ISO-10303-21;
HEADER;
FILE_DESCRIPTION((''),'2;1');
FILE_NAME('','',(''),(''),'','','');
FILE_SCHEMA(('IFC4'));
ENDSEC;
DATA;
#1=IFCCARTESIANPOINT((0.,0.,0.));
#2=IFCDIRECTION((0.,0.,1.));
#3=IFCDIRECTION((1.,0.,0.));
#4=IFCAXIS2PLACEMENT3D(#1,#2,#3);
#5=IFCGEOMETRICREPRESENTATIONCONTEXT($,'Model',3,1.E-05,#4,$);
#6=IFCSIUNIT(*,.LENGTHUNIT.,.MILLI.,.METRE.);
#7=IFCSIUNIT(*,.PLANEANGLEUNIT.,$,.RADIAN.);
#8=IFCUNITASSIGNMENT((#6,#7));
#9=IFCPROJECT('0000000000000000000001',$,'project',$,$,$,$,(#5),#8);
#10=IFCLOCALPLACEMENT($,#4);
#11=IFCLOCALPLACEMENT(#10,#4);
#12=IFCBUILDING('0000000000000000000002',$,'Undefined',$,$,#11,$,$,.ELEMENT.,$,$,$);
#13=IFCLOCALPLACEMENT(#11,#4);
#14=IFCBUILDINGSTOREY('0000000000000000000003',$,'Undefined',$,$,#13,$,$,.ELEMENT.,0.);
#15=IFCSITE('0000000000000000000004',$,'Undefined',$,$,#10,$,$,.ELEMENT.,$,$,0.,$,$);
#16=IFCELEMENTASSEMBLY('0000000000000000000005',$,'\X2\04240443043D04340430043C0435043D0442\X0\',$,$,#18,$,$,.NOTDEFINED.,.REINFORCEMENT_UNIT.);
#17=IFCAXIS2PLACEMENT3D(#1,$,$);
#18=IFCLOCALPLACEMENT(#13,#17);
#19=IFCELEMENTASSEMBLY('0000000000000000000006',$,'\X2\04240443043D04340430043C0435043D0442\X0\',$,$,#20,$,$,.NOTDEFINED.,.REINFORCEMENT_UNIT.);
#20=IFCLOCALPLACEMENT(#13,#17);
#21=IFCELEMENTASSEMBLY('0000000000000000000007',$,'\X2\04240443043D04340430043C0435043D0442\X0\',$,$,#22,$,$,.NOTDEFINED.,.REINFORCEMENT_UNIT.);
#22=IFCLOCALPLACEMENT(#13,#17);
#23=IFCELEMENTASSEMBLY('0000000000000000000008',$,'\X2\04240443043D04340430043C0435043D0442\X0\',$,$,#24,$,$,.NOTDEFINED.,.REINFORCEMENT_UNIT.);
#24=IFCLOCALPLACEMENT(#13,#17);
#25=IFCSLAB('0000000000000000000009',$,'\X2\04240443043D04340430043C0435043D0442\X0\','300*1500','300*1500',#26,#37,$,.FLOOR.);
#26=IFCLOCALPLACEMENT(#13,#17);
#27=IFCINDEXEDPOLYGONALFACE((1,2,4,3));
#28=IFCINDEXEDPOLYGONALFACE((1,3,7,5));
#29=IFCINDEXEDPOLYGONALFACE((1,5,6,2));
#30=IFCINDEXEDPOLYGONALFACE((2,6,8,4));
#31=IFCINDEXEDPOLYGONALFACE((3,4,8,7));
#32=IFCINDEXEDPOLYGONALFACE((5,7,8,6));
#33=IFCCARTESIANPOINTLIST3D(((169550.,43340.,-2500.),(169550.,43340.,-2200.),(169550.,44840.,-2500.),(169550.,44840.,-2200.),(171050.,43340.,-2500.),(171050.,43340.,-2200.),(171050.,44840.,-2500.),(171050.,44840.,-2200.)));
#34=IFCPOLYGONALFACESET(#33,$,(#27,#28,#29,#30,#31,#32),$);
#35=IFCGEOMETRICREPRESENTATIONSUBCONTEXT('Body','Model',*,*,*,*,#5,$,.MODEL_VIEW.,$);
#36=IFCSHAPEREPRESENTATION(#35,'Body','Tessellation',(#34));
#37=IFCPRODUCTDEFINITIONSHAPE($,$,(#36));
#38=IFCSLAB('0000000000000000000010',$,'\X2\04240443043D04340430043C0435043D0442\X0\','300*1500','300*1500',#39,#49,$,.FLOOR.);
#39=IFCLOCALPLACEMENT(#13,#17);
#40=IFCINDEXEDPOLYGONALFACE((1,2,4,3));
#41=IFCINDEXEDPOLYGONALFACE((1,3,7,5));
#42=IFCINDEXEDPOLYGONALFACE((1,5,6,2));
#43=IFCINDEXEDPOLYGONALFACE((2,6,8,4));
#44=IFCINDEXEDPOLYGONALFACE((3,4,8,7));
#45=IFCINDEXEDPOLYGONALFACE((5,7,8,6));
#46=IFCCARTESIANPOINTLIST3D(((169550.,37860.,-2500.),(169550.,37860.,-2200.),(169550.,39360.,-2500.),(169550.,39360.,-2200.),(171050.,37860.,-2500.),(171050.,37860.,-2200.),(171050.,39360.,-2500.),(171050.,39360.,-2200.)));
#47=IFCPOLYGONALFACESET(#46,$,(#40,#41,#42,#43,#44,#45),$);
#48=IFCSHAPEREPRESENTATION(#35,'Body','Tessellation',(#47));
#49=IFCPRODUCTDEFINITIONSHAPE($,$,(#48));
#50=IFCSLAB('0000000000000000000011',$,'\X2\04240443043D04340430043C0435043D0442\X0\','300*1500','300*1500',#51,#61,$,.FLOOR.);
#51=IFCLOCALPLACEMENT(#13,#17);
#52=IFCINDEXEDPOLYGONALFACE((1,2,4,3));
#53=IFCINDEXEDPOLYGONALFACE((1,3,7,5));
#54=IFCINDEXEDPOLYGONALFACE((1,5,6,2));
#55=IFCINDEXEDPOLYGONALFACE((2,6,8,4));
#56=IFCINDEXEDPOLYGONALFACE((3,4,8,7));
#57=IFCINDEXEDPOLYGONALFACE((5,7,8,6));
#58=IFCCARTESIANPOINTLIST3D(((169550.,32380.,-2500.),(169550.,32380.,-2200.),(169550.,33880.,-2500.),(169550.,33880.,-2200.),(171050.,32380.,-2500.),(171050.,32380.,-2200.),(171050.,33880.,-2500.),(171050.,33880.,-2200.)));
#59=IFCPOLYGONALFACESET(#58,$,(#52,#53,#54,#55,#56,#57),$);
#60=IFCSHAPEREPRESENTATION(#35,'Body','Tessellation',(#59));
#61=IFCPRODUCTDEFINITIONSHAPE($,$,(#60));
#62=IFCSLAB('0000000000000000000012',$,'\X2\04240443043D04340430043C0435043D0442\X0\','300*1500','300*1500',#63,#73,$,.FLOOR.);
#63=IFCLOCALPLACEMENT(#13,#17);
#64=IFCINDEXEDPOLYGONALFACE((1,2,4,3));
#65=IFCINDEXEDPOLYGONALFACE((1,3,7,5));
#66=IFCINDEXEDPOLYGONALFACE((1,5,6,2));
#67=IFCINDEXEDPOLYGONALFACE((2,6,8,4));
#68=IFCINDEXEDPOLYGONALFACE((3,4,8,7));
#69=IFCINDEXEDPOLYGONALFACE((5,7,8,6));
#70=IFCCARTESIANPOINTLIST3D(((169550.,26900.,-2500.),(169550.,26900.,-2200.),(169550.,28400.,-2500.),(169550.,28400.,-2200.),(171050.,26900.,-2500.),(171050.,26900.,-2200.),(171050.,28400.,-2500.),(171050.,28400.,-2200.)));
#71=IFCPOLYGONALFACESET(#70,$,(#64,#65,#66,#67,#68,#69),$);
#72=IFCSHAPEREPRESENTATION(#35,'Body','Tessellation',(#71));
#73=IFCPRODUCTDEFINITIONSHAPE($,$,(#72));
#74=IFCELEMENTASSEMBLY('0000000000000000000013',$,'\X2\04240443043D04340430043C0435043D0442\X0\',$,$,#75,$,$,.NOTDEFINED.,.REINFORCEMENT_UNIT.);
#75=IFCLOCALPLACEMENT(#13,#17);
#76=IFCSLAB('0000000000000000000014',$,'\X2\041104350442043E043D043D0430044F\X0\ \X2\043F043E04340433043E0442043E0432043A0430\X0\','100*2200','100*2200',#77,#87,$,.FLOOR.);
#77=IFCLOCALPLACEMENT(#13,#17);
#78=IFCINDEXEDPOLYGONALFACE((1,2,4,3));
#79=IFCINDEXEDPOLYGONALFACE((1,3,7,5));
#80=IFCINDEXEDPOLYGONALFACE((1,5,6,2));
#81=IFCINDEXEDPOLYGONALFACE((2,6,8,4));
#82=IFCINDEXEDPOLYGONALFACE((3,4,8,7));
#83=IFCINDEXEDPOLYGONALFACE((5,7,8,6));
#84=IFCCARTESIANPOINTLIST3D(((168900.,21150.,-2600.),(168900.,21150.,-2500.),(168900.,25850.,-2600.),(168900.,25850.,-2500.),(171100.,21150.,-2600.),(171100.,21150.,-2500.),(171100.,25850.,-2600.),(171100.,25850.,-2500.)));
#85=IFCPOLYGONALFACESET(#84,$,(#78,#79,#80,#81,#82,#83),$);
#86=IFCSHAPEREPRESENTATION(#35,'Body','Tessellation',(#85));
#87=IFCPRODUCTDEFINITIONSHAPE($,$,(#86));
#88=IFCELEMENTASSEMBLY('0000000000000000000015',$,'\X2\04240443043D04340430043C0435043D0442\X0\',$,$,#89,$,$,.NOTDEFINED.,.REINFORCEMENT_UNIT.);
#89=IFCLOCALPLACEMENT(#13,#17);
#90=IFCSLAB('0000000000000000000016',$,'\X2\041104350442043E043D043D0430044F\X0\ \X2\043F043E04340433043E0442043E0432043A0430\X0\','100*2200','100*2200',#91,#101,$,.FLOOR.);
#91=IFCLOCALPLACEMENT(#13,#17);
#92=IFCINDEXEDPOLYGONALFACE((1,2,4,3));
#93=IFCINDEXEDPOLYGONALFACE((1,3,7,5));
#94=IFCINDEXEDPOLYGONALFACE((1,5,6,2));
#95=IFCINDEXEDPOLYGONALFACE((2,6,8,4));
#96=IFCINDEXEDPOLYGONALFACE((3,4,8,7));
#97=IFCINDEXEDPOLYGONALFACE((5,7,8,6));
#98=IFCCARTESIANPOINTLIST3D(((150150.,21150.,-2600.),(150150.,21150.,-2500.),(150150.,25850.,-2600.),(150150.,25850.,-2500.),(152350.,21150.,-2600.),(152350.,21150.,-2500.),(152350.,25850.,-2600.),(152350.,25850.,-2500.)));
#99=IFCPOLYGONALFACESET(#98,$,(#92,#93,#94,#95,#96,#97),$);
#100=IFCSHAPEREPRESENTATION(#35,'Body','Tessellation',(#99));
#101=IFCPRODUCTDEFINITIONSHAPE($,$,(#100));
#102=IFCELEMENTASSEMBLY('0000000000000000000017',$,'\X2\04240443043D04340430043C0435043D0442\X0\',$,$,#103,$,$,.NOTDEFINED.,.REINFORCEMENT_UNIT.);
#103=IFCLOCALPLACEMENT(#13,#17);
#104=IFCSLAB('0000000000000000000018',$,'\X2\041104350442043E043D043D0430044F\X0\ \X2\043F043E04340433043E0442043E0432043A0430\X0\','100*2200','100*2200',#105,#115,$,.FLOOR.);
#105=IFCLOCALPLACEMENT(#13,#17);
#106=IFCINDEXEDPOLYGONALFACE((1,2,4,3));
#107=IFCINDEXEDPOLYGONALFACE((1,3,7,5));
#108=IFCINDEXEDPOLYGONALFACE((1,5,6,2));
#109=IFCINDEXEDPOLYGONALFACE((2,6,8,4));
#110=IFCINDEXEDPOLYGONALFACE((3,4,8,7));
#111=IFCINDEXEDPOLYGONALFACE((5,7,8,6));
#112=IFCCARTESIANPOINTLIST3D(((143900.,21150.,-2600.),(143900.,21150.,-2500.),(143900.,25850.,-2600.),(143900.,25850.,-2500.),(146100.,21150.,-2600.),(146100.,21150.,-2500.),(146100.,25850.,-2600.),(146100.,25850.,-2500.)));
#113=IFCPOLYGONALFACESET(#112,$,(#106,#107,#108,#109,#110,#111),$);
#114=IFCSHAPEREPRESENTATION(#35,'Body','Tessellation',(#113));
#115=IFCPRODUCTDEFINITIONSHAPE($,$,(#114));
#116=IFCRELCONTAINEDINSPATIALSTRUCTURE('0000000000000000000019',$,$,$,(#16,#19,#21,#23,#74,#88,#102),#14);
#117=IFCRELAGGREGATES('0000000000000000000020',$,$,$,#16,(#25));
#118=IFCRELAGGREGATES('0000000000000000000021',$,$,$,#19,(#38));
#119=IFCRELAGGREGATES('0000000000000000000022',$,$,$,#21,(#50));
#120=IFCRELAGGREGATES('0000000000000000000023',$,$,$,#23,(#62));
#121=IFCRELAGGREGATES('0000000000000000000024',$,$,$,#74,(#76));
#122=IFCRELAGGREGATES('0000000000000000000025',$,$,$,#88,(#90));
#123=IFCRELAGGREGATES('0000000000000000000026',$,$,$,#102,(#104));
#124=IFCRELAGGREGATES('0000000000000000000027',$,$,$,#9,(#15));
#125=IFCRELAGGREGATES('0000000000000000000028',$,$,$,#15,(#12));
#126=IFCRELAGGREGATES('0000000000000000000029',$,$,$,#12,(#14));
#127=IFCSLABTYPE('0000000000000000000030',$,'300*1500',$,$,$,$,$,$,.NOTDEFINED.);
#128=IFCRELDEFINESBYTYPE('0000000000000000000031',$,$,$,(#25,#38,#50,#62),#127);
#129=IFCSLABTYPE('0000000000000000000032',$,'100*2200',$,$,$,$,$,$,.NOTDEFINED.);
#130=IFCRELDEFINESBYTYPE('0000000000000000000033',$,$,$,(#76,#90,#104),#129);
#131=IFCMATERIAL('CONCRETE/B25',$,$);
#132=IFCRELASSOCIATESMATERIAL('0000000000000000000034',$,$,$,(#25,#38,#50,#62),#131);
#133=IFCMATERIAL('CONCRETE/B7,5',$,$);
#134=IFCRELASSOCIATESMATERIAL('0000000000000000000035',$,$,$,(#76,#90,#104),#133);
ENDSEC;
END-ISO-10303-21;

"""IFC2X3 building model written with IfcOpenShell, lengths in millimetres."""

from ifc_helpers import new_model, si_unit, frame, origin_with_axes, place, context, subcontext, project, spatial, polyline, outline, extrude, material, type_object, element, aggregate, save


model = new_model("IFC2X3")

# Units and contexts
model_context = context("Model", 3, precision=1e-05, world=origin_with_axes())
body_context = subcontext(model_context, "Body", "Model", "MODEL_VIEW")
ifc_project = project(units=[si_unit("LENGTHUNIT", "METRE", prefix="MILLI"), si_unit("PLANEANGLEUNIT", "RADIAN")], contexts=[model_context])

# Site, building, storey
site_placement = place(None, origin_with_axes())
site = spatial("IfcSite", under=ifc_project, at=site_placement, Name="Undefined", CompositionType="ELEMENT", RefElevation=0.0)
building_placement = place(site_placement, origin_with_axes())
building = spatial("IfcBuilding", under=site, at=building_placement, Name="Undefined", CompositionType="ELEMENT")
storey_placement = place(building_placement, origin_with_axes())
storey = spatial("IfcBuildingStorey", under=building, at=storey_placement, Name="Undefined", CompositionType="ELEMENT", Elevation=0.0)

# Element assemblies
ifc_material_1 = material(Name="CONCRETE/B7,5")
assembly_1_placement = place(storey_placement, origin_with_axes())
assembly_1 = element("IfcElementAssembly", 1, at=assembly_1_placement, inside=storey, Name="Фундамент", AssemblyPlace="NOTDEFINED", PredefinedType="REINFORCEMENT_UNIT")
assembly_2_placement = place(storey_placement, origin_with_axes())
assembly_2 = element("IfcElementAssembly", 2, at=assembly_2_placement, inside=storey, Name="Фундамент", AssemblyPlace="NOTDEFINED", PredefinedType="REINFORCEMENT_UNIT")
assembly_3_placement = place(storey_placement, origin_with_axes())
assembly_3 = element("IfcElementAssembly", 3, at=assembly_3_placement, inside=storey, Name="Фундамент", AssemblyPlace="NOTDEFINED", PredefinedType="REINFORCEMENT_UNIT")
assembly_4_placement = place(storey_placement, origin_with_axes())
assembly_4 = element("IfcElementAssembly", 4, at=assembly_4_placement, inside=storey, Name="Фундамент", AssemblyPlace="NOTDEFINED", PredefinedType="REINFORCEMENT_UNIT")

# Slabs
ifc_material_2 = material(Name="CONCRETE/B25")
slab_type_1 = type_object("IfcSlabType", Name="300*1500", PredefinedType="NOTDEFINED")
slab_1_placement = place(assembly_1_placement, frame((169550.0, 44840.0, -2350.0), z_axis=(0.0, 0.0, 1.0), x_axis=(0.0, -1.0, 0.0)))
slab_1 = element("IfcSlab", 5, at=slab_1_placement, type_object=slab_type_1, material=ifc_material_2, Name="Фундамент", Description="300*1500", ObjectType="300*1500", PredefinedType="FLOOR", context=body_context, shape_type="SweptSolid", body=[
    extrude(outline(polyline([(0.0, 0.0), (1500.0, 0.0), (1500.0, 1500.0), (0.0, 1500.0), (0.0, 0.0)])), frame((0.0, 0.0, -150.0), z_axis=(0.0, 0.0, 1.0), x_axis=(1.0, 0.0, 0.0)), (0.0, 0.0, 1.0), 300.0),
])
aggregate(assembly_1, [slab_1])
slab_2_placement = place(assembly_2_placement, frame((169550.0, 39360.0, -2350.0), z_axis=(0.0, 0.0, 1.0), x_axis=(0.0, -1.0, 0.0)))
slab_2 = element("IfcSlab", 6, at=slab_2_placement, type_object=slab_type_1, material=ifc_material_2, Name="Фундамент", Description="300*1500", ObjectType="300*1500", PredefinedType="FLOOR", context=body_context, shape_type="SweptSolid", body=[
    extrude(outline(polyline([(0.0, 0.0), (1500.0, 0.0), (1500.0, 1500.0), (0.0, 1500.0), (0.0, 0.0)])), frame((0.0, 0.0, -150.0), z_axis=(0.0, 0.0, 1.0), x_axis=(1.0, 0.0, 0.0)), (0.0, 0.0, 1.0), 300.0),
])
aggregate(assembly_2, [slab_2])
slab_3_placement = place(assembly_3_placement, frame((169550.0, 33880.0, -2350.0), z_axis=(0.0, 0.0, 1.0), x_axis=(0.0, -1.0, 0.0)))
slab_3 = element("IfcSlab", 7, at=slab_3_placement, type_object=slab_type_1, material=ifc_material_2, Name="Фундамент", Description="300*1500", ObjectType="300*1500", PredefinedType="FLOOR", context=body_context, shape_type="SweptSolid", body=[
    extrude(outline(polyline([(0.0, 0.0), (1500.0, 0.0), (1500.0, 1500.0), (0.0, 1500.0), (0.0, 0.0)])), frame((0.0, 0.0, -150.0), z_axis=(0.0, 0.0, 1.0), x_axis=(1.0, 0.0, 0.0)), (0.0, 0.0, 1.0), 300.0),
])
aggregate(assembly_3, [slab_3])
slab_4_placement = place(assembly_4_placement, frame((169550.0, 28400.0, -2350.0), z_axis=(0.0, 0.0, 1.0), x_axis=(0.0, -1.0, 0.0)))
slab_4 = element("IfcSlab", 8, at=slab_4_placement, type_object=slab_type_1, material=ifc_material_2, Name="Фундамент", Description="300*1500", ObjectType="300*1500", PredefinedType="FLOOR", context=body_context, shape_type="SweptSolid", body=[
    extrude(outline(polyline([(0.0, 0.0), (1500.0, 0.0), (1500.0, 1500.0), (0.0, 1500.0), (0.0, 0.0)])), frame((0.0, 0.0, -150.0), z_axis=(0.0, 0.0, 1.0), x_axis=(1.0, 0.0, 0.0)), (0.0, 0.0, 1.0), 300.0),
])
aggregate(assembly_4, [slab_4])

# Element assemblies, slabs
assembly_5_placement = place(storey_placement, origin_with_axes())
assembly_5 = element("IfcElementAssembly", 9, at=assembly_5_placement, inside=storey, Name="Фундамент", AssemblyPlace="NOTDEFINED", PredefinedType="REINFORCEMENT_UNIT")
slab_type_2 = type_object("IfcSlabType", Name="100*2200", PredefinedType="NOTDEFINED")
slab_5_placement = place(assembly_5_placement, frame((168900.0, 25850.0, -2550.0), z_axis=(0.0, 0.0, 1.0), x_axis=(0.0, -1.0, 0.0)))
slab_5 = element("IfcSlab", 10, at=slab_5_placement, type_object=slab_type_2, material=ifc_material_1, Name="Бетонная подготовка", Description="100*2200", ObjectType="100*2200", PredefinedType="FLOOR", context=body_context, shape_type="SweptSolid", body=[
    extrude(outline(polyline([(0.0, 0.0), (4700.0, 0.0), (4700.0, 2200.0), (0.0, 2200.0), (0.0, 0.0)])), frame((0.0, 0.0, -50.0), z_axis=(0.0, 0.0, 1.0), x_axis=(1.0, 0.0, 0.0)), (0.0, 0.0, 1.0), 100.0),
])
aggregate(assembly_5, [slab_5])
assembly_6_placement = place(storey_placement, origin_with_axes())
assembly_6 = element("IfcElementAssembly", 11, at=assembly_6_placement, inside=storey, Name="Фундамент", AssemblyPlace="NOTDEFINED", PredefinedType="REINFORCEMENT_UNIT")
slab_6_placement = place(assembly_6_placement, frame((150150.0, 25850.0, -2550.0), z_axis=(0.0, 0.0, 1.0), x_axis=(0.0, -1.0, 0.0)))
slab_6 = element("IfcSlab", 12, at=slab_6_placement, type_object=slab_type_2, material=ifc_material_1, Name="Бетонная подготовка", Description="100*2200", ObjectType="100*2200", PredefinedType="FLOOR", context=body_context, shape_type="SweptSolid", body=[
    extrude(outline(polyline([(0.0, 0.0), (4700.0, 0.0), (4700.0, 2200.0), (0.0, 2200.0), (0.0, 0.0)])), frame((0.0, 0.0, -50.0), z_axis=(0.0, 0.0, 1.0), x_axis=(1.0, 0.0, 0.0)), (0.0, 0.0, 1.0), 100.0),
])
aggregate(assembly_6, [slab_6])
assembly_7_placement = place(storey_placement, origin_with_axes())
assembly_7 = element("IfcElementAssembly", 13, at=assembly_7_placement, inside=storey, Name="Фундамент", AssemblyPlace="NOTDEFINED", PredefinedType="REINFORCEMENT_UNIT")
slab_7_placement = place(assembly_7_placement, frame((143900.0, 25850.0, -2550.0), z_axis=(0.0, 0.0, 1.0), x_axis=(0.0, -1.0, 0.0)))
slab_7 = element("IfcSlab", 14, at=slab_7_placement, type_object=slab_type_2, material=ifc_material_1, Name="Бетонная подготовка", Description="100*2200", ObjectType="100*2200", PredefinedType="FLOOR", context=body_context, shape_type="SweptSolid", body=[
    extrude(outline(polyline([(0.0, 0.0), (4700.0, 0.0), (4700.0, 2200.0), (0.0, 2200.0), (0.0, 0.0)])), frame((0.0, 0.0, -50.0), z_axis=(0.0, 0.0, 1.0), x_axis=(1.0, 0.0, 0.0)), (0.0, 0.0, 1.0), 100.0),
])
aggregate(assembly_7, [slab_7])

save(model, "model.ifc")
